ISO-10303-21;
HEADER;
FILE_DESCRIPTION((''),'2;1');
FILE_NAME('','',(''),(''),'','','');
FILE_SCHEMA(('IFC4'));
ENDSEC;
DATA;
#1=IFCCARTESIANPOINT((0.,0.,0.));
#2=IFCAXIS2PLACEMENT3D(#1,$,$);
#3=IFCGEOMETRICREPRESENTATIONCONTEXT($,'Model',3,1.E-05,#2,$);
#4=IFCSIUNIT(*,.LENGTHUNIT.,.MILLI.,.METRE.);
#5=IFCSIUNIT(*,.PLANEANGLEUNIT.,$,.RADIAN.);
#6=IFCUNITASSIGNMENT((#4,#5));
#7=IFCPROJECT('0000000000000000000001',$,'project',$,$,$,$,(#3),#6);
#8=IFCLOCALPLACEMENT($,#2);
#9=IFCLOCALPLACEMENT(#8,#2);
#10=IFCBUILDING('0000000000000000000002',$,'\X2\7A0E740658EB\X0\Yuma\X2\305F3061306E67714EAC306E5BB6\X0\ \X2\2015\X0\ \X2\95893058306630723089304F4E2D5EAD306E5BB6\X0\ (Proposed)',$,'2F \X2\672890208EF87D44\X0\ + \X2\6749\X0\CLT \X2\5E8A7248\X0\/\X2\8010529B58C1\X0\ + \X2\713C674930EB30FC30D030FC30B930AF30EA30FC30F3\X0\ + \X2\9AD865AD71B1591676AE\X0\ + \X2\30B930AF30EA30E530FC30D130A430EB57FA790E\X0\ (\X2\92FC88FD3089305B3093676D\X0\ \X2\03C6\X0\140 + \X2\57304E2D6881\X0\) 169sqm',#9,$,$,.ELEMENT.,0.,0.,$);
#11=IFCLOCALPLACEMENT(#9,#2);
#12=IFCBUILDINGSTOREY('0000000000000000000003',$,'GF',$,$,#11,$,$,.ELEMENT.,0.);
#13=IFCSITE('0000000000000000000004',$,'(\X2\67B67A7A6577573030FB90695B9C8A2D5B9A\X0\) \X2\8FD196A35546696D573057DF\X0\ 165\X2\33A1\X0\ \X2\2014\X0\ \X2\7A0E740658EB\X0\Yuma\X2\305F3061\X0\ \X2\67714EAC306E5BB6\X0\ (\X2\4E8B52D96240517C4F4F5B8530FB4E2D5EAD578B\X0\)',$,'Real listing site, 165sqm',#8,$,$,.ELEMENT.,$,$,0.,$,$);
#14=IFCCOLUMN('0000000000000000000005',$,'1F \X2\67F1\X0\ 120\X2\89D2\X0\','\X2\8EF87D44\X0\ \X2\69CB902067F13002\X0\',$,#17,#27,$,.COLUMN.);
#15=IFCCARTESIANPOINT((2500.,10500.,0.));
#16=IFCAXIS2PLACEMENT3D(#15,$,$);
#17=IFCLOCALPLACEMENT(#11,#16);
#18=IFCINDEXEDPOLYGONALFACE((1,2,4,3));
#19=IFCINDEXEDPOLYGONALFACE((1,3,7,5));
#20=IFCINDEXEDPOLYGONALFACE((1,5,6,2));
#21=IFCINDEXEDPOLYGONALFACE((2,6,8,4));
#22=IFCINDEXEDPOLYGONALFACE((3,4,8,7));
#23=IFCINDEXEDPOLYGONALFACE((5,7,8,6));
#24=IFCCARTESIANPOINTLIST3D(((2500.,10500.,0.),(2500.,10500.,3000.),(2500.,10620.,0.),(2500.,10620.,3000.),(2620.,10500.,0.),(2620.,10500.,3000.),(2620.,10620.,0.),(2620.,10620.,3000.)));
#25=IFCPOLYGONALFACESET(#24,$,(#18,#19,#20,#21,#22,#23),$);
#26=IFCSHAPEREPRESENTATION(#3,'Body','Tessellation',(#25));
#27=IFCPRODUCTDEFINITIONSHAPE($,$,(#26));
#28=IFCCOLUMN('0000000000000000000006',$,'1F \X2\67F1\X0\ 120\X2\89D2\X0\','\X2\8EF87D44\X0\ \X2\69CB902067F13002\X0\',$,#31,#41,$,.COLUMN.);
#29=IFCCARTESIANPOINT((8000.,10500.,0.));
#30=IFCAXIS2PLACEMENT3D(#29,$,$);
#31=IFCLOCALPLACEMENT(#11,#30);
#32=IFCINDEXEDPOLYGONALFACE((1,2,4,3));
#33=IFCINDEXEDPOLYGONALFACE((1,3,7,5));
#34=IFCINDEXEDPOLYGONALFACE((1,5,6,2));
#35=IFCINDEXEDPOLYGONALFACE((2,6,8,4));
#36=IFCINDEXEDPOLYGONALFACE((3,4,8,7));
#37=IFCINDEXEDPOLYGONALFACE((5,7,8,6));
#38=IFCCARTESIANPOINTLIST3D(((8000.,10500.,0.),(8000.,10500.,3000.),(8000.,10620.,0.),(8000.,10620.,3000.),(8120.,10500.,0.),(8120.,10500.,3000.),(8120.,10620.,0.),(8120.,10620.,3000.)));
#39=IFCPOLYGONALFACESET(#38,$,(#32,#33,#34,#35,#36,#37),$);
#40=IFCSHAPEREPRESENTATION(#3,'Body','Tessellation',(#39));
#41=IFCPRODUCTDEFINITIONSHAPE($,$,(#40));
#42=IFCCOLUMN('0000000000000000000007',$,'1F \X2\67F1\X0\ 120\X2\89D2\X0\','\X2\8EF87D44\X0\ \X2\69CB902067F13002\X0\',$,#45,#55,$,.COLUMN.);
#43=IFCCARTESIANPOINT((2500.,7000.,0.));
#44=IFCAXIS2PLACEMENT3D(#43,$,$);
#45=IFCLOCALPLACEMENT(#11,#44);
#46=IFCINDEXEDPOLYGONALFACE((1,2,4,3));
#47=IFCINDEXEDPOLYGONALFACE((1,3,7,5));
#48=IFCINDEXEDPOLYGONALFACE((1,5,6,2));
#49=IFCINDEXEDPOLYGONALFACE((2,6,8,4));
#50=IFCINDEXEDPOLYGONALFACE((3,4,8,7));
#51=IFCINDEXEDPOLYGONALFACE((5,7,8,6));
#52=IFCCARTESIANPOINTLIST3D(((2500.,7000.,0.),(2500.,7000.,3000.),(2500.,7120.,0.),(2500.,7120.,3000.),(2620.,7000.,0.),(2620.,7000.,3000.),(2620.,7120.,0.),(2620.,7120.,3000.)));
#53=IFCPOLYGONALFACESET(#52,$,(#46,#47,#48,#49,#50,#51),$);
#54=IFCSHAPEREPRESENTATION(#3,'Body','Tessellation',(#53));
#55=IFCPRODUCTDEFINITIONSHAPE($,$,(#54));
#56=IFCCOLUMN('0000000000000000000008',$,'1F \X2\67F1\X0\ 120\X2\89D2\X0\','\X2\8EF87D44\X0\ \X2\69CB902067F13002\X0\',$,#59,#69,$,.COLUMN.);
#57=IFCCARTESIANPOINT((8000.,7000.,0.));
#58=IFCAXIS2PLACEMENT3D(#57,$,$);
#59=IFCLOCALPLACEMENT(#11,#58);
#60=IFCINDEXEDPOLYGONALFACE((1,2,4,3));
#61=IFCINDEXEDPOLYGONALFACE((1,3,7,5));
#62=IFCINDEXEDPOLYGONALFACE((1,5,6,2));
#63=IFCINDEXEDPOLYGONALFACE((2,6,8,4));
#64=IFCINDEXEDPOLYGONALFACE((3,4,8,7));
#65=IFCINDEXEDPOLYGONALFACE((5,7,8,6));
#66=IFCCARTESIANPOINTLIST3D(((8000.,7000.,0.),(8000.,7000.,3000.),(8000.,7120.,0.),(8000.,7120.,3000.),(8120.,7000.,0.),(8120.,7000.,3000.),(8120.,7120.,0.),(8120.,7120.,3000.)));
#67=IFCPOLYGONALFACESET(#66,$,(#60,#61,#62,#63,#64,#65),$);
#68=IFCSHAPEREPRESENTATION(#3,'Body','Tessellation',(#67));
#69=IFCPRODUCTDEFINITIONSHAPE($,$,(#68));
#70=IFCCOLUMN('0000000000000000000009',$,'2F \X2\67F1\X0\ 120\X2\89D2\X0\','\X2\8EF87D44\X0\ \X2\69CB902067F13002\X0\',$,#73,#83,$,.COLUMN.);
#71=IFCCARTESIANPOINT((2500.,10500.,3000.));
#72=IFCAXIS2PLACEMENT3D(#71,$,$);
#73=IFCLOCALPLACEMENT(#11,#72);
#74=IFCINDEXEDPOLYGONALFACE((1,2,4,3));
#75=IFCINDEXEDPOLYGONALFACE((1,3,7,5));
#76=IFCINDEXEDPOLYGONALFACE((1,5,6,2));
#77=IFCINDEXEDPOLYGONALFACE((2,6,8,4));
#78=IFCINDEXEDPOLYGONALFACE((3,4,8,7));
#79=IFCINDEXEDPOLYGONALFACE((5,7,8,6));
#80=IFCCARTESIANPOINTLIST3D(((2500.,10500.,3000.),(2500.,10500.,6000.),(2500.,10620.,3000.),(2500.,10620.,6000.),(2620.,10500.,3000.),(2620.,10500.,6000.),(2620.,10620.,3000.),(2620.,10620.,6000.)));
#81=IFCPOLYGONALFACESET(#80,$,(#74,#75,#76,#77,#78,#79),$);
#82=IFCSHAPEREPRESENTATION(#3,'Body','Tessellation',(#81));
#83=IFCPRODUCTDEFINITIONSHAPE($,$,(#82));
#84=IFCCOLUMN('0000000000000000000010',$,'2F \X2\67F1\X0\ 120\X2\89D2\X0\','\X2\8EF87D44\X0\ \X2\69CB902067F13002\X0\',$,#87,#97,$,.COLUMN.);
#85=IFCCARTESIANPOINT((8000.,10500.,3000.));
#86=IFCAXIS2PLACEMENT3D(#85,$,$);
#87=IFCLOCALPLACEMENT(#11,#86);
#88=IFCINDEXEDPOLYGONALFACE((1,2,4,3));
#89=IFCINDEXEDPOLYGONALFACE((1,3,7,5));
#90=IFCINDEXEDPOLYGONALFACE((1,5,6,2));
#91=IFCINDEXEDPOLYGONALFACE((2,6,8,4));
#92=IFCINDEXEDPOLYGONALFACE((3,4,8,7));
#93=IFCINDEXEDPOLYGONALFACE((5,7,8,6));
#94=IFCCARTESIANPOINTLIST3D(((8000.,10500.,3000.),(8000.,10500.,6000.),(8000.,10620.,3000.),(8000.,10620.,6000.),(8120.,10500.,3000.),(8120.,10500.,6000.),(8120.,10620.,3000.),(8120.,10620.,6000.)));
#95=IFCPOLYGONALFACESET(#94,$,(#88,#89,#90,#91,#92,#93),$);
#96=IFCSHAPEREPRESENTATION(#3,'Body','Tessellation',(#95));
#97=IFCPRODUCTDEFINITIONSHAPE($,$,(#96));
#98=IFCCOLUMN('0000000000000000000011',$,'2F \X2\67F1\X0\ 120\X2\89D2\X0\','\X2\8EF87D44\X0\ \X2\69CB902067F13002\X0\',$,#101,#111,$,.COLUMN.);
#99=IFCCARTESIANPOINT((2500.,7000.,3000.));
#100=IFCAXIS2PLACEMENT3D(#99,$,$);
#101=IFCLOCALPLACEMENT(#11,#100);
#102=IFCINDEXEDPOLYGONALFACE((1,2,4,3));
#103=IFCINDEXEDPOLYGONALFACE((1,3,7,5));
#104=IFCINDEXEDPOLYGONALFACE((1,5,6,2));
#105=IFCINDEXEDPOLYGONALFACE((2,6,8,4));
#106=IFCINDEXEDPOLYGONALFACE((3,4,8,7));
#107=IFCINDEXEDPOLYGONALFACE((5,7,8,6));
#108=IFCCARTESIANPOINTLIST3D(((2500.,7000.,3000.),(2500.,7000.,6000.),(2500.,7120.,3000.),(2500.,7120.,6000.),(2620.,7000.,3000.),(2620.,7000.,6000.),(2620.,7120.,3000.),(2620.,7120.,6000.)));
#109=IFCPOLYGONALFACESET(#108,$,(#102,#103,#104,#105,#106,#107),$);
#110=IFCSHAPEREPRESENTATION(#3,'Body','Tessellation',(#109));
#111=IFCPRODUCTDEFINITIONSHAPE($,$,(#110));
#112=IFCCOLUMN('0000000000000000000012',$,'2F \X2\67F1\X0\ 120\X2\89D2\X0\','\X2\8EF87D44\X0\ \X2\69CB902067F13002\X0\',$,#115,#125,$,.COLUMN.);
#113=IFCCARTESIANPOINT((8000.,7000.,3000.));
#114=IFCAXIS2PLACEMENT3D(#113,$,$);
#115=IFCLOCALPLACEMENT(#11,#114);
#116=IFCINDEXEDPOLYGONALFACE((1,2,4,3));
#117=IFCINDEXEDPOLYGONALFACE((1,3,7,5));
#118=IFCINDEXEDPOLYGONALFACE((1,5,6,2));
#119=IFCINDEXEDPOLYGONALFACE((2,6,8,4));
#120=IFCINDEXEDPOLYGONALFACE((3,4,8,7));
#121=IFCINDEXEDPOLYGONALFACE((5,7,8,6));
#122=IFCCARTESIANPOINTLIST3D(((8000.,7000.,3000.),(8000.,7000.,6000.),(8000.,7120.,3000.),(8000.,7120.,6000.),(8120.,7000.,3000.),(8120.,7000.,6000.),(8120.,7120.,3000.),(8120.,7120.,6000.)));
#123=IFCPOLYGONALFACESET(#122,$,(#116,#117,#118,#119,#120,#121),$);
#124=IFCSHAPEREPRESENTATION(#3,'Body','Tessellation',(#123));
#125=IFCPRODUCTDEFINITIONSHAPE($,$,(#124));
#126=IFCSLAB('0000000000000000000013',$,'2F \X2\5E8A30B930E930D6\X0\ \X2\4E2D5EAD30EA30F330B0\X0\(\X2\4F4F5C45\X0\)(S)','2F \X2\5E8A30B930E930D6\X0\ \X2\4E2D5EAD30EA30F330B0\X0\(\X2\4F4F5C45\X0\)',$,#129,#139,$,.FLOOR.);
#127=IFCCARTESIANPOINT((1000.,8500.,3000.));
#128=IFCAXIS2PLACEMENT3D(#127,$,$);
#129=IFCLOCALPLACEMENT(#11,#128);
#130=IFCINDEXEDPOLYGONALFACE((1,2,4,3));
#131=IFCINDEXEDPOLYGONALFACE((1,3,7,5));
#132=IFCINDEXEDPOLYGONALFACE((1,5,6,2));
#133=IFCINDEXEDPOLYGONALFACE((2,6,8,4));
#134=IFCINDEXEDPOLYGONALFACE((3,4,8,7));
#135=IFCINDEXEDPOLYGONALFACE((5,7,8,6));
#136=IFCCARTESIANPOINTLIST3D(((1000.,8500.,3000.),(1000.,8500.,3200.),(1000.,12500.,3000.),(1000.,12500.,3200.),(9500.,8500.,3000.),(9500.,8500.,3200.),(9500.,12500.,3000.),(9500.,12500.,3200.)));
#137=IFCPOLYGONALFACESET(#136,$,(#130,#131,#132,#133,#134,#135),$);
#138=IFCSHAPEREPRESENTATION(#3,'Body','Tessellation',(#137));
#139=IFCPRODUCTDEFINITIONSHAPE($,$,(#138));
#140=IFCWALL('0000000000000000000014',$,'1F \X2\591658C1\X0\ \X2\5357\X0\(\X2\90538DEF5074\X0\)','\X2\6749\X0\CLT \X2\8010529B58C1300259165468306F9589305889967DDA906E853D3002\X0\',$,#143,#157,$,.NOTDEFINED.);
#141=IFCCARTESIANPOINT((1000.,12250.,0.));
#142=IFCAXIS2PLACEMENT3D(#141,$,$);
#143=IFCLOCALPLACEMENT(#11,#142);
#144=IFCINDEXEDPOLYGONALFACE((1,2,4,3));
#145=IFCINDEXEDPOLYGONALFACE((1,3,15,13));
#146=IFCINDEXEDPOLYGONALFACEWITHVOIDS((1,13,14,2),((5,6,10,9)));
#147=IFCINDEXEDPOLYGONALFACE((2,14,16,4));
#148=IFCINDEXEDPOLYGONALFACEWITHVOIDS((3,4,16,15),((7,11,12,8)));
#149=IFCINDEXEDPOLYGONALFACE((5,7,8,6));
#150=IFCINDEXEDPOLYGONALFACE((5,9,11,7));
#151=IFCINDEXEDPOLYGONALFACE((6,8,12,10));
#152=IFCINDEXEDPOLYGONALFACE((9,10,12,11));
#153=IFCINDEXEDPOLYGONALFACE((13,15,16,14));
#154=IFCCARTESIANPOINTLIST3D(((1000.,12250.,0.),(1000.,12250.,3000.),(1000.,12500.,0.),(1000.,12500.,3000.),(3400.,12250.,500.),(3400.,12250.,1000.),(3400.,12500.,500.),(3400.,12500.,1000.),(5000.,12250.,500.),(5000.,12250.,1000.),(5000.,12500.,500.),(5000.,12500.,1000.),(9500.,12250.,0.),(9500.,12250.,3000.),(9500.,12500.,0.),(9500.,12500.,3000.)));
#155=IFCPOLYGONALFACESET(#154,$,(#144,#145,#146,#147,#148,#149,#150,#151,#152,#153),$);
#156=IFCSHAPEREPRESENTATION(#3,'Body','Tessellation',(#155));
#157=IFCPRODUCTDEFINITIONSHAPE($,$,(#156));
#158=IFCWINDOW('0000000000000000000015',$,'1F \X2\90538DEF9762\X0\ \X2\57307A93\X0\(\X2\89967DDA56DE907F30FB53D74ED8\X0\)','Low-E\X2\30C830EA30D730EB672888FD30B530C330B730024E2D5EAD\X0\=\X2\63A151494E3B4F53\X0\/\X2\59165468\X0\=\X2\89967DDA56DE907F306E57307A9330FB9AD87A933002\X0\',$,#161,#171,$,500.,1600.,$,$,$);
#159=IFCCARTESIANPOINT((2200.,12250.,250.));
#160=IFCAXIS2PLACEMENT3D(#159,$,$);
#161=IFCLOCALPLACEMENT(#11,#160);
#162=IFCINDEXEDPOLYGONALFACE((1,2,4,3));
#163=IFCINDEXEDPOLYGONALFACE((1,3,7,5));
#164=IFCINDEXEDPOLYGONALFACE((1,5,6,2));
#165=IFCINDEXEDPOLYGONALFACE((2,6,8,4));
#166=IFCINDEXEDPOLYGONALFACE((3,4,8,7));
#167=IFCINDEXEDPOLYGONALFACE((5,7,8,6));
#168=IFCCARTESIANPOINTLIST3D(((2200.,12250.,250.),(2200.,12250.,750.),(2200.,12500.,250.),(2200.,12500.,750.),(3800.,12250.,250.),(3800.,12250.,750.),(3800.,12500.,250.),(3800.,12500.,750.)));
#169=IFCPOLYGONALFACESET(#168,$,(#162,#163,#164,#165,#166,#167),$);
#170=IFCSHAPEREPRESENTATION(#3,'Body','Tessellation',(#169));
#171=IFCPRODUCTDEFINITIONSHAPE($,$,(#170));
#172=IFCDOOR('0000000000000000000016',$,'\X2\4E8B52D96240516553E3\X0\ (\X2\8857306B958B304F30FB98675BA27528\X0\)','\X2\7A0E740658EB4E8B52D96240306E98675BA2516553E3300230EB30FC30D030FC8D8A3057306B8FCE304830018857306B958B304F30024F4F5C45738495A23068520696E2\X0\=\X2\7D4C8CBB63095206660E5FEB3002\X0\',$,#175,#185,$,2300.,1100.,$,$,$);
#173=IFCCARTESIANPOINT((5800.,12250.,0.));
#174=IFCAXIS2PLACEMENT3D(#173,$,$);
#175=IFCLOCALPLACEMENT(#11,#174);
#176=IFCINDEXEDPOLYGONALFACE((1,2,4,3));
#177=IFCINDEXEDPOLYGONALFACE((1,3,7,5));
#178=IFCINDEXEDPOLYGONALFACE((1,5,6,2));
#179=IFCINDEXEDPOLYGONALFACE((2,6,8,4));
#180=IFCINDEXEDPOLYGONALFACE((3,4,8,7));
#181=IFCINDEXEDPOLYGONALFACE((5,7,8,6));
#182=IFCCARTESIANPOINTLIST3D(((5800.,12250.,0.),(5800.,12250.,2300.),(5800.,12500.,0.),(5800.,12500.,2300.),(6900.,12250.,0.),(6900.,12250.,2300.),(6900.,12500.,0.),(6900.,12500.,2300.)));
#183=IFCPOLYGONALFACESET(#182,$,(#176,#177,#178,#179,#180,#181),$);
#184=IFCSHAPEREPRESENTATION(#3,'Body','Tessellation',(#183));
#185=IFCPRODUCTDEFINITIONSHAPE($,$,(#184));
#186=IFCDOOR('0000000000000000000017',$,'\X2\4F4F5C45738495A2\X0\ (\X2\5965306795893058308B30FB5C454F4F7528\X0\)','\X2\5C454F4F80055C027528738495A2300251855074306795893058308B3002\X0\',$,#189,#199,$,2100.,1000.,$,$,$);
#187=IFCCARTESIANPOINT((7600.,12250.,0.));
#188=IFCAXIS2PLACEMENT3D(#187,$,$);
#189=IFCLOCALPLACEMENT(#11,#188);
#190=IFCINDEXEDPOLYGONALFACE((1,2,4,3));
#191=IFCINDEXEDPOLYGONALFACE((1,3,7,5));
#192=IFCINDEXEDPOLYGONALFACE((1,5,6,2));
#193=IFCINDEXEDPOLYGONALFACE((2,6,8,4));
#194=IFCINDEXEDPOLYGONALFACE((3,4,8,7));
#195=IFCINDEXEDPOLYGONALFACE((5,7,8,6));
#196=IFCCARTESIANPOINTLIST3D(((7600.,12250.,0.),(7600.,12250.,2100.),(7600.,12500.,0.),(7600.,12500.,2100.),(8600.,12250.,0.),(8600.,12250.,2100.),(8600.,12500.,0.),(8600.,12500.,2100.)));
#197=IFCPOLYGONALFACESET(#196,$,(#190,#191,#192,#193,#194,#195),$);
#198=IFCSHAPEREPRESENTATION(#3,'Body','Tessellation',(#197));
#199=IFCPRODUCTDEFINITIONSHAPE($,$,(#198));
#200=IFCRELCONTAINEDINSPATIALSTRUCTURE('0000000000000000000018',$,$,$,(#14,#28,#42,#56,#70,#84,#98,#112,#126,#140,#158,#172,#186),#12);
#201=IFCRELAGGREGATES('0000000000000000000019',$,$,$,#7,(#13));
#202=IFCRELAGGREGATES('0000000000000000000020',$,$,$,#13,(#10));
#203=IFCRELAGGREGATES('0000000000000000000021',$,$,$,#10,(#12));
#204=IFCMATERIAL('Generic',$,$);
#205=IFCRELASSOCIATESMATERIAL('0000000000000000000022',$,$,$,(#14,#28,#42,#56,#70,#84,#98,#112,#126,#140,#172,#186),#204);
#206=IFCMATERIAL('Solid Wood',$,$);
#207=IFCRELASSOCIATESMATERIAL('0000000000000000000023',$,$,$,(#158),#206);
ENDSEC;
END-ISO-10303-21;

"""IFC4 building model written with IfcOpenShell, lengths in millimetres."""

from ifc_helpers import new_model, si_unit, frame, frame_2d, origin, place, context, project, spatial, rectangle, extrude, material, element, fill, save


model = new_model("IFC4")

# Units and contexts
model_context = context("Model", 3, precision=1e-05, world=origin())
ifc_project = project(units=[si_unit("LENGTHUNIT", "METRE", prefix="MILLI"), si_unit("PLANEANGLEUNIT", "RADIAN")], contexts=[model_context])

# Site, building, storey
site_placement = place(None, origin())
site = spatial("IfcSite", under=ifc_project, at=site_placement, Name="(架空敷地・適宜設定) 近隣商業地域 165㎡ — 税理士Yumaたち 東京の家 (事務所兼住宅・中庭型)", ObjectType="Real listing site, 165sqm", CompositionType="ELEMENT", RefElevation=0.0)
building_placement = place(site_placement, origin())
building = spatial("IfcBuilding", under=site, at=building_placement, Name="税理士Yumaたちの東京の家 ― 閉じてひらく中庭の家 (Proposed)", ObjectType="2F 木造軸組 + 杉CLT 床版/耐力壁 + 焼杉ルーバースクリーン + 高断熱外皮 + スクリューパイル基礎 (鋼製らせん杭 φ140 + 地中梁) 169sqm", CompositionType="ELEMENT", ElevationOfRefHeight=0.0, ElevationOfTerrain=0.0)
storey_placement = place(building_placement, origin())
storey = spatial("IfcBuildingStorey", under=building, at=storey_placement, Name="GF", CompositionType="ELEMENT", Elevation=0.0)

# Columns
ifc_material_1 = material(Name="Generic")
column_1_placement = place(storey_placement, frame((2500.0, 10500.0, 0.0)))
element("IfcColumn", 1, at=column_1_placement, inside=storey, material=ifc_material_1, Name="1F 柱 120角", Description="軸組 構造柱。", PredefinedType="COLUMN", context=model_context, shape_type="SweptSolid", body=[
    extrude(rectangle(XDim=120.0, YDim=120.0, at=frame_2d((60.0, 60.0))), frame((2500.0, 10500.0, 0.0)), (0.0, 0.0, 1.0), 3000.0),
])
column_2_placement = place(storey_placement, frame((8000.0, 10500.0, 0.0)))
element("IfcColumn", 2, at=column_2_placement, inside=storey, material=ifc_material_1, Name="1F 柱 120角", Description="軸組 構造柱。", PredefinedType="COLUMN", context=model_context, shape_type="SweptSolid", body=[
    extrude(rectangle(XDim=120.0, YDim=120.0, at=frame_2d((60.0, 60.0))), frame((8000.0, 10500.0, 0.0)), (0.0, 0.0, 1.0), 3000.0),
])
column_3_placement = place(storey_placement, frame((2500.0, 7000.0, 0.0)))
element("IfcColumn", 3, at=column_3_placement, inside=storey, material=ifc_material_1, Name="1F 柱 120角", Description="軸組 構造柱。", PredefinedType="COLUMN", context=model_context, shape_type="SweptSolid", body=[
    extrude(rectangle(XDim=120.0, YDim=120.0, at=frame_2d((60.0, 60.0))), frame((2500.0, 7000.0, 0.0)), (0.0, 0.0, 1.0), 3000.0),
])
column_4_placement = place(storey_placement, frame((8000.0, 7000.0, 0.0)))
element("IfcColumn", 4, at=column_4_placement, inside=storey, material=ifc_material_1, Name="1F 柱 120角", Description="軸組 構造柱。", PredefinedType="COLUMN", context=model_context, shape_type="SweptSolid", body=[
    extrude(rectangle(XDim=120.0, YDim=120.0, at=frame_2d((60.0, 60.0))), frame((8000.0, 7000.0, 0.0)), (0.0, 0.0, 1.0), 3000.0),
])
column_5_placement = place(storey_placement, frame((2500.0, 10500.0, 3000.0)))
element("IfcColumn", 5, at=column_5_placement, inside=storey, material=ifc_material_1, Name="2F 柱 120角", Description="軸組 構造柱。", PredefinedType="COLUMN", context=model_context, shape_type="SweptSolid", body=[
    extrude(rectangle(XDim=120.0, YDim=120.0, at=frame_2d((60.0, 60.0))), frame((2500.0, 10500.0, 3000.0)), (0.0, 0.0, 1.0), 3000.0),
])
column_6_placement = place(storey_placement, frame((8000.0, 10500.0, 3000.0)))
element("IfcColumn", 6, at=column_6_placement, inside=storey, material=ifc_material_1, Name="2F 柱 120角", Description="軸組 構造柱。", PredefinedType="COLUMN", context=model_context, shape_type="SweptSolid", body=[
    extrude(rectangle(XDim=120.0, YDim=120.0, at=frame_2d((60.0, 60.0))), frame((8000.0, 10500.0, 3000.0)), (0.0, 0.0, 1.0), 3000.0),
])
column_7_placement = place(storey_placement, frame((2500.0, 7000.0, 3000.0)))
element("IfcColumn", 7, at=column_7_placement, inside=storey, material=ifc_material_1, Name="2F 柱 120角", Description="軸組 構造柱。", PredefinedType="COLUMN", context=model_context, shape_type="SweptSolid", body=[
    extrude(rectangle(XDim=120.0, YDim=120.0, at=frame_2d((60.0, 60.0))), frame((2500.0, 7000.0, 3000.0)), (0.0, 0.0, 1.0), 3000.0),
])
column_8_placement = place(storey_placement, frame((8000.0, 7000.0, 3000.0)))
element("IfcColumn", 8, at=column_8_placement, inside=storey, material=ifc_material_1, Name="2F 柱 120角", Description="軸組 構造柱。", PredefinedType="COLUMN", context=model_context, shape_type="SweptSolid", body=[
    extrude(rectangle(XDim=120.0, YDim=120.0, at=frame_2d((60.0, 60.0))), frame((8000.0, 7000.0, 3000.0)), (0.0, 0.0, 1.0), 3000.0),
])

# Slab
slab_1_placement = place(storey_placement, frame((1000.0, 8500.0, 3000.0)))
element("IfcSlab", 9, at=slab_1_placement, inside=storey, material=ifc_material_1, Name="2F 床スラブ 中庭リング(住居)(S)", Description="2F 床スラブ 中庭リング(住居)", PredefinedType="FLOOR", context=model_context, shape_type="SweptSolid", body=[
    extrude(rectangle(XDim=8500.0, YDim=4000.0, at=frame_2d((4250.0, 2000.0))), frame((1000.0, 8500.0, 3000.0)), (0.0, 0.0, 1.0), 200.0),
])

# Wall, openings, window, doors
wall_1_placement = place(storey_placement, frame((1000.0, 12250.0, 0.0)))
wall_1 = element("IfcWall", 10, at=wall_1_placement, inside=storey, material=ifc_material_1, Name="1F 外壁 南(道路側)", Description="杉CLT 耐力壁。外周は閉じ視線遮蔽。", PredefinedType="NOTDEFINED", context=model_context, shape_type="SweptSolid", body=[
    extrude(rectangle(XDim=8500.0, YDim=250.0, at=frame_2d((4250.0, 125.0))), frame((1000.0, 12250.0, 0.0)), (0.0, 0.0, 1.0), 3000.0),
])
opening_1_placement = place(storey_placement, frame((2200.0, 12250.0, 250.0)))
opening_1 = element("IfcOpeningElement", 11, at=opening_1_placement, cuts=wall_1, PredefinedType="NOTDEFINED", context=model_context, shape_type="SweptSolid", body=[
    extrude(rectangle(XDim=1600.0, YDim=250.0, at=frame_2d((800.0, 125.0))), frame((2200.0, 12250.0, 250.0)), (0.0, 0.0, 1.0), 500.0),
])
opening_2_placement = place(storey_placement, frame((5800.0, 12250.0, 0.0)))
opening_2 = element("IfcOpeningElement", 12, at=opening_2_placement, cuts=wall_1, PredefinedType="NOTDEFINED", context=model_context, shape_type="SweptSolid", body=[
    extrude(rectangle(XDim=1100.0, YDim=250.0, at=frame_2d((550.0, 125.0))), frame((5800.0, 12250.0, 0.0)), (0.0, 0.0, 1.0), 2300.0),
])
opening_3_placement = place(storey_placement, frame((7600.0, 12250.0, 0.0)))
opening_3 = element("IfcOpeningElement", 13, at=opening_3_placement, cuts=wall_1, PredefinedType="NOTDEFINED", context=model_context, shape_type="SweptSolid", body=[
    extrude(rectangle(XDim=1000.0, YDim=250.0, at=frame_2d((500.0, 125.0))), frame((7600.0, 12250.0, 0.0)), (0.0, 0.0, 1.0), 2100.0),
])
ifc_material_2 = material(Name="Solid Wood")
window_1_placement = place(storey_placement, frame((2200.0, 12250.0, 250.0)))
window_1 = element("IfcWindow", 14, at=window_1_placement, inside=storey, material=ifc_material_2, Name="1F 道路面 地窓(視線回避・受付)", Description="Low-Eトリプル木製サッシ。中庭=採光主体/外周=視線回避の地窓・高窓。", OverallHeight=500.0, OverallWidth=1600.0, context=model_context, shape_type="SweptSolid", body=[
    extrude(rectangle(XDim=1600.0, YDim=250.0, at=frame_2d((800.0, 125.0))), frame((2200.0, 12250.0, 250.0)), (0.0, 0.0, 1.0), 500.0),
])
fill(opening_1, window_1)
door_1_placement = place(storey_placement, frame((5800.0, 12250.0, 0.0)))
door_1 = element("IfcDoor", 15, at=door_1_placement, inside=storey, material=ifc_material_1, Name="事務所入口 (街に開く・顧客用)", Description="税理士事務所の顧客入口。ルーバー越しに迎え、街に開く。住居玄関と分離=経費按分明快。", OverallHeight=2300.0, OverallWidth=1100.0, context=model_context, shape_type="SweptSolid", body=[
    extrude(rectangle(XDim=1100.0, YDim=250.0, at=frame_2d((550.0, 125.0))), frame((5800.0, 12250.0, 0.0)), (0.0, 0.0, 1.0), 2300.0),
])
fill(opening_2, door_1)
door_2_placement = place(storey_placement, frame((7600.0, 12250.0, 0.0)))
door_2 = element("IfcDoor", 16, at=door_2_placement, inside=storey, material=ifc_material_1, Name="住居玄関 (奥で閉じる・居住用)", Description="居住者専用玄関。内側で閉じる。", OverallHeight=2100.0, OverallWidth=1000.0, context=model_context, shape_type="SweptSolid", body=[
    extrude(rectangle(XDim=1000.0, YDim=250.0, at=frame_2d((500.0, 125.0))), frame((7600.0, 12250.0, 0.0)), (0.0, 0.0, 1.0), 2100.0),
])
fill(opening_3, door_2)

save(model, "model.ifc")
